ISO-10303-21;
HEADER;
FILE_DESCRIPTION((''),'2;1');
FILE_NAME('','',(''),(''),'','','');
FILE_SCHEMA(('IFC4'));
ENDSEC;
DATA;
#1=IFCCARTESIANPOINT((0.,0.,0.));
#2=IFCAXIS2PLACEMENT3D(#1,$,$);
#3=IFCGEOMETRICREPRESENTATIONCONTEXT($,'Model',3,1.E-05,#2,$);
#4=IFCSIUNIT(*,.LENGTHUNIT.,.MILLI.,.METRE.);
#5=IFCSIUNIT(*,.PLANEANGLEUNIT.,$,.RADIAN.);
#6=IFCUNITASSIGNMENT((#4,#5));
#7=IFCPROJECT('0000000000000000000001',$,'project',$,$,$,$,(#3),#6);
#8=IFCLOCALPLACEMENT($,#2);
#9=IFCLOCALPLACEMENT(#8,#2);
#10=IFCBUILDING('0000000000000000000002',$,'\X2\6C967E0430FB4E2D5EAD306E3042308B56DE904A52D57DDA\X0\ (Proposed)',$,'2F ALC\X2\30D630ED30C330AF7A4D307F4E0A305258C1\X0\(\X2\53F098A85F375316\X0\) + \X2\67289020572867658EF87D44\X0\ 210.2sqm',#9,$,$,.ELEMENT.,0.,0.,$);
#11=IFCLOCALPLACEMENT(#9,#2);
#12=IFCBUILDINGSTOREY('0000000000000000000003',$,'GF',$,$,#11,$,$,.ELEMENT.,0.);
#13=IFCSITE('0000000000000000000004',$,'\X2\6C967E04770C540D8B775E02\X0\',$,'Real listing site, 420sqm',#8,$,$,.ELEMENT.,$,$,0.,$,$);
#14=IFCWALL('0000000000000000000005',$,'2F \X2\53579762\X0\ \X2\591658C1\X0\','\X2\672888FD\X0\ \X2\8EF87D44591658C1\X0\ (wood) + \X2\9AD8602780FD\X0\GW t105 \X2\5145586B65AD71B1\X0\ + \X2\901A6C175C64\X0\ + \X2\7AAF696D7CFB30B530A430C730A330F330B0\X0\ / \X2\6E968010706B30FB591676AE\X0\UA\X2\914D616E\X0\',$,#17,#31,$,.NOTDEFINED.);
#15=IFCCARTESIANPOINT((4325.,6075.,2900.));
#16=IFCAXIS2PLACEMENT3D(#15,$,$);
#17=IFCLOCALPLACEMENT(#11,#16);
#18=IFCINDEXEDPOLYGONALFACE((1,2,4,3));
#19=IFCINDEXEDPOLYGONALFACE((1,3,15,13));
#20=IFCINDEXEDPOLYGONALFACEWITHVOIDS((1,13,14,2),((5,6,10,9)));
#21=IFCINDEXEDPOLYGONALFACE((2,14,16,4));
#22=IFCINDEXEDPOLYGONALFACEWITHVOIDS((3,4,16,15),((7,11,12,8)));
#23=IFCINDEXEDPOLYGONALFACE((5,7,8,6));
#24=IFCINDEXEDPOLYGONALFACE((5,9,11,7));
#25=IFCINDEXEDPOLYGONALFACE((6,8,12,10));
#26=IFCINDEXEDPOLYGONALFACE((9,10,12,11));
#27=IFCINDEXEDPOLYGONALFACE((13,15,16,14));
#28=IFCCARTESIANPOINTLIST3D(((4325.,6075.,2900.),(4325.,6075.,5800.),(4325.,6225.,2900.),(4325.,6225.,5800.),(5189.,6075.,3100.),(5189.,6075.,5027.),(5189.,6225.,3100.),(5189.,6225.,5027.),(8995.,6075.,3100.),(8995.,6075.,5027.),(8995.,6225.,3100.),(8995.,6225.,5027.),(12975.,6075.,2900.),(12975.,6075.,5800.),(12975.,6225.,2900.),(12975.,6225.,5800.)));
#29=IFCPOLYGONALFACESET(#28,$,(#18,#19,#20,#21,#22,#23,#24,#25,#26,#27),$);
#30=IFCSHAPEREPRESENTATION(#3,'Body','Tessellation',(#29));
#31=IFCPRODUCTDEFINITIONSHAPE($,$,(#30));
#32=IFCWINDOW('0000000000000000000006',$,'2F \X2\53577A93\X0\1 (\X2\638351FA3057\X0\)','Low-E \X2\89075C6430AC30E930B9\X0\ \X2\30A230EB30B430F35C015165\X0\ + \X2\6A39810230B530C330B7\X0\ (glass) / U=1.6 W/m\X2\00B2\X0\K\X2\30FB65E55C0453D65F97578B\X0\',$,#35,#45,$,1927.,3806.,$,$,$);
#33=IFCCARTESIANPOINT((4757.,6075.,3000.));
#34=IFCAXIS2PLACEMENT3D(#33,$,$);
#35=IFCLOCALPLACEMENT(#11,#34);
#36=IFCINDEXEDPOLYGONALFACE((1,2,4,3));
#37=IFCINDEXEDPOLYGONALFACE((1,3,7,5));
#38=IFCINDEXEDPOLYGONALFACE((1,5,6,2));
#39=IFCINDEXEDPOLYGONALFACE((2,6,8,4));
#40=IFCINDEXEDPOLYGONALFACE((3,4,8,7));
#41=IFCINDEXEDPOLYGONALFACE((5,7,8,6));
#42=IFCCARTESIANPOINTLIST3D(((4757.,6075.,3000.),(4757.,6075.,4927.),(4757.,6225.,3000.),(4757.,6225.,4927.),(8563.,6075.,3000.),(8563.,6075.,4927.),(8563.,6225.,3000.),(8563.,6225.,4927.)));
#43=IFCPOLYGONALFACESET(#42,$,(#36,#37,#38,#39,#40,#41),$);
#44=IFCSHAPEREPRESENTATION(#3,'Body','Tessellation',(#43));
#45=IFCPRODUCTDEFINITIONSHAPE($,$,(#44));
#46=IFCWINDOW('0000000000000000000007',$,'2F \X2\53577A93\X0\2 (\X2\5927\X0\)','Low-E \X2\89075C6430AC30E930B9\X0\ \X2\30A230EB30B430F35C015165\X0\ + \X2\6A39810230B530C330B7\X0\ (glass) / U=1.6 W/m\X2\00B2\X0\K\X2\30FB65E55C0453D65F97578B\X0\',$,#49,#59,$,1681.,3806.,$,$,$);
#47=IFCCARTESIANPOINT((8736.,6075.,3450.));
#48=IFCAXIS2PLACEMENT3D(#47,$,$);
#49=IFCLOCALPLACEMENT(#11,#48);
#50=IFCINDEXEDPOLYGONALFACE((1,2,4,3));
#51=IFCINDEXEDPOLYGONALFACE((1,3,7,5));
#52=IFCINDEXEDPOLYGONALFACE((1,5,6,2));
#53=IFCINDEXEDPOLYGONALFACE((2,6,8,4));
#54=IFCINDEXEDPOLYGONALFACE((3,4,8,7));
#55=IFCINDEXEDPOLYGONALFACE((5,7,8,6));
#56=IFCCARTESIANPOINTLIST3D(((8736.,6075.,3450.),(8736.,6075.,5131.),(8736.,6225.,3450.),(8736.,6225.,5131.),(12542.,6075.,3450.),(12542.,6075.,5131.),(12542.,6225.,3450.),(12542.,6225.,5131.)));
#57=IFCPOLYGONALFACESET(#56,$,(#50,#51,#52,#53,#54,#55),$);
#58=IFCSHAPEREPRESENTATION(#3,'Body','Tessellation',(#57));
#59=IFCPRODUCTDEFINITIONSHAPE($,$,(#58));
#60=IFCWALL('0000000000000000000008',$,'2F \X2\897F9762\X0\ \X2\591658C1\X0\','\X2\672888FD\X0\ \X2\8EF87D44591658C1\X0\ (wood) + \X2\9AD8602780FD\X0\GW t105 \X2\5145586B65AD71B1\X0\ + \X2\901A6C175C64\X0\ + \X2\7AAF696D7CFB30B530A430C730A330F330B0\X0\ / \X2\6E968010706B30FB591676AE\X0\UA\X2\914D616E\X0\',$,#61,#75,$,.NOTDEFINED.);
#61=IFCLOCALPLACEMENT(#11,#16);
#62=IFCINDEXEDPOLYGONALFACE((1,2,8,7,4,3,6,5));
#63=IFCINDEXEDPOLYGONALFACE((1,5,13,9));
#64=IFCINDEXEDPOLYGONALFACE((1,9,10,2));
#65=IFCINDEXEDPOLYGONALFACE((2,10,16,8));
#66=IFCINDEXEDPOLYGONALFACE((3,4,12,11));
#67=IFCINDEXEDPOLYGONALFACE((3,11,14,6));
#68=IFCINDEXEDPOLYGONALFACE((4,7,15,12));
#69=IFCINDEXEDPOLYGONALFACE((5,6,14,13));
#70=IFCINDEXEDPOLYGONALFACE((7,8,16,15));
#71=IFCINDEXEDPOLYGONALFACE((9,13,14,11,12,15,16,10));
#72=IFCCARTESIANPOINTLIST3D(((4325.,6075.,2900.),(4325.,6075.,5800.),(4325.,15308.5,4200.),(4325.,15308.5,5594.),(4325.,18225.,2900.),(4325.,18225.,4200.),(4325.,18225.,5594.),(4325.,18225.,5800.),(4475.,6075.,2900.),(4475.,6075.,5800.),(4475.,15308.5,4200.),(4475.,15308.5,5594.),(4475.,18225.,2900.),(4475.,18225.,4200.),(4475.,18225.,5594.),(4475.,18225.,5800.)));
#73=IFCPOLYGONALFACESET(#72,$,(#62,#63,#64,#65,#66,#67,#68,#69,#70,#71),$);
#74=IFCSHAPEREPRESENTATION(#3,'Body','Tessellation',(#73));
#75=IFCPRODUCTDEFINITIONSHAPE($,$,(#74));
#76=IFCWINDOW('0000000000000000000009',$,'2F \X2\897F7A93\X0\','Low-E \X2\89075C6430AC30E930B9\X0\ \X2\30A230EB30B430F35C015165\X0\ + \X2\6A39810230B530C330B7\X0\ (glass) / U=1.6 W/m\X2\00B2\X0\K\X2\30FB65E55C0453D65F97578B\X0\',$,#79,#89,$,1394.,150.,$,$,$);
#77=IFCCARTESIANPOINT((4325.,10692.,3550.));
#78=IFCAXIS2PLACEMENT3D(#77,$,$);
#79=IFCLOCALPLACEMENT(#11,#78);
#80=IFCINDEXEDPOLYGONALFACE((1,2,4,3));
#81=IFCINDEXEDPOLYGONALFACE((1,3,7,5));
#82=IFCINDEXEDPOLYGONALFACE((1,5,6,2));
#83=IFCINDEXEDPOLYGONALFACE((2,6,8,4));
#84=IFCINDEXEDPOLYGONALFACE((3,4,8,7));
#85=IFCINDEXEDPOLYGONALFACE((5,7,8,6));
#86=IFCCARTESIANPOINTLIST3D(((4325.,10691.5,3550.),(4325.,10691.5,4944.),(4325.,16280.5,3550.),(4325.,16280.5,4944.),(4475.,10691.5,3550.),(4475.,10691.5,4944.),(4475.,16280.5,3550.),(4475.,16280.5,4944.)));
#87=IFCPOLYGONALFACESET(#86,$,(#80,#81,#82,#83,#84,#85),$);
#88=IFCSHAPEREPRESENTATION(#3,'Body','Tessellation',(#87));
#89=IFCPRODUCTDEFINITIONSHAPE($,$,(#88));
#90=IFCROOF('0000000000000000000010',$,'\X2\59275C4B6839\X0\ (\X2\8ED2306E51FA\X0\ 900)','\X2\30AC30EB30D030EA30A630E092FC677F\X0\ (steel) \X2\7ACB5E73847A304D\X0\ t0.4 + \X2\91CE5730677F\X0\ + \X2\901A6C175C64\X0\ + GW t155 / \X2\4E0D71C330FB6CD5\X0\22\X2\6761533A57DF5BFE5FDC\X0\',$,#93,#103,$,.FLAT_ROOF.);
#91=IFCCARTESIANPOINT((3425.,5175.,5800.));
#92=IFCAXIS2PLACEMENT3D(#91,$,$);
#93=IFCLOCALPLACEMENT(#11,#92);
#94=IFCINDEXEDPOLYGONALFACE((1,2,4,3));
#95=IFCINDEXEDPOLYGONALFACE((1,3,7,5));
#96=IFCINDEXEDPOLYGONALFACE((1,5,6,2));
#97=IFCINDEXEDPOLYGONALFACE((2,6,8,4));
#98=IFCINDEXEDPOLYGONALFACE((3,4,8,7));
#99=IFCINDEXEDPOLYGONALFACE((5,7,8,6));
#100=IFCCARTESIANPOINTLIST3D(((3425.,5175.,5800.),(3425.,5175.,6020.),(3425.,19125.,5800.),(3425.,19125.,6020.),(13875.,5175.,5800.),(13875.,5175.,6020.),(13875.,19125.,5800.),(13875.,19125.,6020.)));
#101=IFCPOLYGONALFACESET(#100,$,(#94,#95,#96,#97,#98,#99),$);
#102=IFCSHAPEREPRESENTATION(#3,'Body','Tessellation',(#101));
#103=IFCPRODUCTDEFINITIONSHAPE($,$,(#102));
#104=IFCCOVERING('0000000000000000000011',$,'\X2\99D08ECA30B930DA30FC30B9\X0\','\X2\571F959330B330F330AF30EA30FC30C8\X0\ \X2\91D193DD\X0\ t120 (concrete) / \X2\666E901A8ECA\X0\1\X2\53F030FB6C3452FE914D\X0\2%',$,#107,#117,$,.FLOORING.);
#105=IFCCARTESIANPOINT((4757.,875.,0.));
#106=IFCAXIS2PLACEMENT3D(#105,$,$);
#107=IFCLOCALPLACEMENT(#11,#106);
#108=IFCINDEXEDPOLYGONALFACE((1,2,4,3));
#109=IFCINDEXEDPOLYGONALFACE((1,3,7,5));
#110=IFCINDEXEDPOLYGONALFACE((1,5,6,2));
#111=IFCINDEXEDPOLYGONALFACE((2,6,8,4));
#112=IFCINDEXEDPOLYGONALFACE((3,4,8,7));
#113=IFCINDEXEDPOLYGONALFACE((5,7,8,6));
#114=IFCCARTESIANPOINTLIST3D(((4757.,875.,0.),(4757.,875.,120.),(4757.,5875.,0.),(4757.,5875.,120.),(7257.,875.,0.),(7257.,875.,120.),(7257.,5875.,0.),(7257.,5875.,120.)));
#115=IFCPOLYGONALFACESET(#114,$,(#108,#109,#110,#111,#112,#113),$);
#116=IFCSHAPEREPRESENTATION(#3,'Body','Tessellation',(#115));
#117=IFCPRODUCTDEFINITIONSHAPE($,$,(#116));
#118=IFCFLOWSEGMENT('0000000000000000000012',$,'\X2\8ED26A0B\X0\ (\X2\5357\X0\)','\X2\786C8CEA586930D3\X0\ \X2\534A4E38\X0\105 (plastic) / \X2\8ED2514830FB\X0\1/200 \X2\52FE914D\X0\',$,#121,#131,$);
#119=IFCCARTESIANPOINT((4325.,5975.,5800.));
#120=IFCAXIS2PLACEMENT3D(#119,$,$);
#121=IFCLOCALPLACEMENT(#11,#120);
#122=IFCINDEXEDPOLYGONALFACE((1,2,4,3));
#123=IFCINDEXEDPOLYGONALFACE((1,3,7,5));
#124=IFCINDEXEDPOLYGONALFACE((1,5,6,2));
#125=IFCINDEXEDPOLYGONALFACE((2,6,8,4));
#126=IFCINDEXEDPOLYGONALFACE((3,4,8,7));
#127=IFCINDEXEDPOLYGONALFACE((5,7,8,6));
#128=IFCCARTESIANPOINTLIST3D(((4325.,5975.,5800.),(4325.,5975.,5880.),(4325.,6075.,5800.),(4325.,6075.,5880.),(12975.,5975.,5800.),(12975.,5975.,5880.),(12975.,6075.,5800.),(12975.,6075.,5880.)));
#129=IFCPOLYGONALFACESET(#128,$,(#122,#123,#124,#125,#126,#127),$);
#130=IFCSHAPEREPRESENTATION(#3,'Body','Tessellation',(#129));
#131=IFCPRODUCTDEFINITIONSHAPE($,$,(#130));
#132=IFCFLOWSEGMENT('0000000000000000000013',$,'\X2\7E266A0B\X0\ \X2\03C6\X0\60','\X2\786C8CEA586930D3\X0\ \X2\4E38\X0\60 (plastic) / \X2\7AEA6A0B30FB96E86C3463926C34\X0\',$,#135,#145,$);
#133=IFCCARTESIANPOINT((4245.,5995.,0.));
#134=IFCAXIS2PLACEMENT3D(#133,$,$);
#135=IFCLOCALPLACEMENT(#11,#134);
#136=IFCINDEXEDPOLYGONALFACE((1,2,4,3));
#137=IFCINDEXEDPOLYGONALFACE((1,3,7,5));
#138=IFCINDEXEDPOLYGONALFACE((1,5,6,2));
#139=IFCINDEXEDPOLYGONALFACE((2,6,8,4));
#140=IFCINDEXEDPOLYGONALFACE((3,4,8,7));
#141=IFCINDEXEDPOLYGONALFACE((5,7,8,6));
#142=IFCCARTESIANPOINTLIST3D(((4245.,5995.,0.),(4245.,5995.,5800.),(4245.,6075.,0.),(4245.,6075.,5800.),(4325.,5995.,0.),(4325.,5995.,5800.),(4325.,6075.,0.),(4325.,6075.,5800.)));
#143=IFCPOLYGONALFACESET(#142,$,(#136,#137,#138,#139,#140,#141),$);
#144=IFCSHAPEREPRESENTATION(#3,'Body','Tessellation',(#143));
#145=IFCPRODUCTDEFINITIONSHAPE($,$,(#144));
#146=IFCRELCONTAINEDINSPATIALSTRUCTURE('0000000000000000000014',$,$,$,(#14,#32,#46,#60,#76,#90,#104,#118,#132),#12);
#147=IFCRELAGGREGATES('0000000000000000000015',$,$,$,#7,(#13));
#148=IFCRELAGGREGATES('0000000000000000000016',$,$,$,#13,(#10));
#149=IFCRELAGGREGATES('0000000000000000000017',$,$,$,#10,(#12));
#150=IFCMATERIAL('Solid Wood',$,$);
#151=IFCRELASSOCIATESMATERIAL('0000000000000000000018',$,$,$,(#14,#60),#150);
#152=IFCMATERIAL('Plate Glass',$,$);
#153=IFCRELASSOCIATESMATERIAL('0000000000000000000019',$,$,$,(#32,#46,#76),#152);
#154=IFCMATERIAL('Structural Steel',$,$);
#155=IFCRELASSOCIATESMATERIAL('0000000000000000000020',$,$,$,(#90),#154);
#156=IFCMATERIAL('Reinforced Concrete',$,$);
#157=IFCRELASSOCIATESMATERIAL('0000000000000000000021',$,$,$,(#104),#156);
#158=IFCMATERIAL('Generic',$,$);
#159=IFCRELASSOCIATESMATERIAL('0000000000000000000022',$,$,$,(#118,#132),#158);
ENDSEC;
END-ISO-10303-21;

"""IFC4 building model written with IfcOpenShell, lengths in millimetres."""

from ifc_helpers import new_model, si_unit, frame, frame_2d, origin, place, context, project, spatial, rectangle, extrude, material, element, fill, save


model = new_model("IFC4")

# Units and contexts
model_context = context("Model", 3, precision=1e-05, world=origin())
ifc_project = project(units=[si_unit("LENGTHUNIT", "METRE", prefix="MILLI"), si_unit("PLANEANGLEUNIT", "RADIAN")], contexts=[model_context])

# Site, building, storey
site_placement = place(None, origin())
site = spatial("IfcSite", under=ifc_project, at=site_placement, Name="沖縄県名護市", ObjectType="Real listing site, 420sqm", CompositionType="ELEMENT", RefElevation=0.0)
building_placement = place(site_placement, origin())
building = spatial("IfcBuilding", under=site, at=building_placement, Name="沖縄・中庭のある回遊動線 (Proposed)", ObjectType="2F ALCブロック積み上げ壁(台風強化) + 木造在来軸組 210.2sqm", CompositionType="ELEMENT", ElevationOfRefHeight=0.0, ElevationOfTerrain=0.0)
storey_placement = place(building_placement, origin())
storey = spatial("IfcBuildingStorey", under=building, at=storey_placement, Name="GF", CompositionType="ELEMENT", Elevation=0.0)

# Shared definitions
ifc_material_1 = material(Name="Solid Wood")

# Shared definitions
ifc_material_2 = material(Name="Reinforced Concrete")

# Shared definitions
ifc_material_3 = material(Name="Plate Glass")

# Wall, openings, windows
wall_1_placement = place(storey_placement, frame((4325.0, 6075.0, 2900.0)))
wall_1 = element("IfcWall", 1, at=wall_1_placement, inside=storey, material=ifc_material_1, Name="2F 南面 外壁", Description="木製 軸組外壁 (wood) + 高性能GW t105 充填断熱 + 通気層 + 窯業系サイディング / 準耐火・外皮UA配慮", PredefinedType="NOTDEFINED", context=model_context, shape_type="SweptSolid", body=[
    extrude(rectangle(XDim=8650.0, YDim=150.0, at=frame_2d((4325.0, 75.0))), frame((4325.0, 6075.0, 2900.0)), (0.0, 0.0, 1.0), 2900.0),
])
opening_1_placement = place(storey_placement, frame((4757.0, 6075.0, 3000.0)))
opening_1 = element("IfcOpeningElement", 2, at=opening_1_placement, cuts=wall_1, PredefinedType="NOTDEFINED", context=model_context, shape_type="SweptSolid", body=[
    extrude(rectangle(XDim=3806.0, YDim=150.0, at=frame_2d((1903.0, 75.0))), frame((4757.0, 6075.0, 3000.0)), (0.0, 0.0, 1.0), 1927.0),
])
opening_2_placement = place(storey_placement, frame((8736.0, 6075.0, 3450.0)))
opening_2 = element("IfcOpeningElement", 3, at=opening_2_placement, cuts=wall_1, PredefinedType="NOTDEFINED", context=model_context, shape_type="SweptSolid", body=[
    extrude(rectangle(XDim=3806.0, YDim=150.0, at=frame_2d((1903.0, 75.0))), frame((8736.0, 6075.0, 3450.0)), (0.0, 0.0, 1.0), 1681.0),
])
window_1_placement = place(storey_placement, frame((4757.0, 6075.0, 3000.0)))
window_1 = element("IfcWindow", 4, at=window_1_placement, inside=storey, material=ifc_material_3, Name="2F 南窓1 (掃出し)", Description="Low-E 複層ガラス アルゴン封入 + 樹脂サッシ (glass) / U=1.6 W/m²K・日射取得型", OverallHeight=1927.0, OverallWidth=3806.0, context=model_context, shape_type="SweptSolid", body=[
    extrude(rectangle(XDim=3806.0, YDim=150.0, at=frame_2d((1903.0, 75.0))), frame((4757.0, 6075.0, 3000.0)), (0.0, 0.0, 1.0), 1927.0),
])
fill(opening_1, window_1)
window_2_placement = place(storey_placement, frame((8736.0, 6075.0, 3450.0)))
window_2 = element("IfcWindow", 5, at=window_2_placement, inside=storey, material=ifc_material_3, Name="2F 南窓2 (大)", Description="Low-E 複層ガラス アルゴン封入 + 樹脂サッシ (glass) / U=1.6 W/m²K・日射取得型", OverallHeight=1681.0, OverallWidth=3806.0, context=model_context, shape_type="SweptSolid", body=[
    extrude(rectangle(XDim=3806.0, YDim=150.0, at=frame_2d((1903.0, 75.0))), frame((8736.0, 6075.0, 3450.0)), (0.0, 0.0, 1.0), 1681.0),
])
fill(opening_2, window_2)

# Wall, opening, window
wall_2_placement = place(storey_placement, frame((4325.0, 6075.0, 2900.0)))
wall_2 = element("IfcWall", 6, at=wall_2_placement, inside=storey, material=ifc_material_1, Name="2F 西面 外壁", Description="木製 軸組外壁 (wood) + 高性能GW t105 充填断熱 + 通気層 + 窯業系サイディング / 準耐火・外皮UA配慮", PredefinedType="NOTDEFINED", context=model_context, shape_type="SweptSolid", body=[
    extrude(rectangle(XDim=150.0, YDim=12150.0, at=frame_2d((75.0, 6075.0))), frame((4325.0, 6075.0, 2900.0)), (0.0, 0.0, 1.0), 2900.0),
])
opening_3_placement = place(storey_placement, frame((4325.0, 10692.0, 3550.0)))
opening_3 = element("IfcOpeningElement", 7, at=opening_3_placement, cuts=wall_2, PredefinedType="NOTDEFINED", context=model_context, shape_type="SweptSolid", body=[
    extrude(rectangle(XDim=150.0, YDim=5589.0, at=frame_2d((75.0, 2794.0))), frame((4325.0, 10692.0, 3550.0)), (0.0, 0.0, 1.0), 1394.0),
])
window_3_placement = place(storey_placement, frame((4325.0, 10692.0, 3550.0)))
window_3 = element("IfcWindow", 8, at=window_3_placement, inside=storey, material=ifc_material_3, Name="2F 西窓", Description="Low-E 複層ガラス アルゴン封入 + 樹脂サッシ (glass) / U=1.6 W/m²K・日射取得型", OverallHeight=1394.0, OverallWidth=150.0, context=model_context, shape_type="SweptSolid", body=[
    extrude(rectangle(XDim=150.0, YDim=5589.0, at=frame_2d((75.0, 2794.0))), frame((4325.0, 10692.0, 3550.0)), (0.0, 0.0, 1.0), 1394.0),
])
fill(opening_3, window_3)

# Roof
ifc_material_4 = material(Name="Structural Steel")
roof_placement = place(storey_placement, frame((3425.0, 5175.0, 5800.0)))
element("IfcRoof", 9, at=roof_placement, inside=storey, material=ifc_material_4, Name="大屋根 (軒の出 900)", Description="ガルバリウム鋼板 (steel) 立平葺き t0.4 + 野地板 + 通気層 + GW t155 / 不燃・法22条区域対応", PredefinedType="FLAT_ROOF", context=model_context, shape_type="SweptSolid", body=[
    extrude(rectangle(XDim=10450.0, YDim=13950.0, at=frame_2d((5225.0, 6975.0))), frame((3425.0, 5175.0, 5800.0)), (0.0, 0.0, 1.0), 220.0),
])

# Covering
covering_placement = place(storey_placement, frame((4757.0, 875.0, 0.0)))
element("IfcCovering", 10, at=covering_placement, inside=storey, material=ifc_material_2, Name="駐車スペース", Description="土間コンクリート 金鏝 t120 (concrete) / 普通車1台・水勾配2%", PredefinedType="FLOORING", context=model_context, shape_type="SweptSolid", body=[
    extrude(rectangle(XDim=2500.0, YDim=5000.0, at=frame_2d((1250.0, 2500.0))), frame((4757.0, 875.0, 0.0)), (0.0, 0.0, 1.0), 120.0),
])

# Flow segments
ifc_material_5 = material(Name="Generic")
flow_segment_1_placement = place(storey_placement, frame((4325.0, 5975.0, 5800.0)))
element("IfcFlowSegment", 11, at=flow_segment_1_placement, inside=storey, material=ifc_material_5, Name="軒樋 (南)", Description="硬質塩ビ 半丸105 (plastic) / 軒先・1/200 勾配", context=model_context, shape_type="SweptSolid", body=[
    extrude(rectangle(XDim=8650.0, YDim=100.0, at=frame_2d((4325.0, 50.0))), frame((4325.0, 5975.0, 5800.0)), (0.0, 0.0, 1.0), 80.0),
])
flow_segment_2_placement = place(storey_placement, frame((4245.0, 5995.0, 0.0)))
element("IfcFlowSegment", 12, at=flow_segment_2_placement, inside=storey, material=ifc_material_5, Name="縦樋 φ60", Description="硬質塩ビ 丸60 (plastic) / 竪樋・雨水排水", context=model_context, shape_type="SweptSolid", body=[
    extrude(rectangle(XDim=80.0, YDim=80.0, at=frame_2d((40.0, 40.0))), frame((4245.0, 5995.0, 0.0)), (0.0, 0.0, 1.0), 5800.0),
])

save(model, "model.ifc")
